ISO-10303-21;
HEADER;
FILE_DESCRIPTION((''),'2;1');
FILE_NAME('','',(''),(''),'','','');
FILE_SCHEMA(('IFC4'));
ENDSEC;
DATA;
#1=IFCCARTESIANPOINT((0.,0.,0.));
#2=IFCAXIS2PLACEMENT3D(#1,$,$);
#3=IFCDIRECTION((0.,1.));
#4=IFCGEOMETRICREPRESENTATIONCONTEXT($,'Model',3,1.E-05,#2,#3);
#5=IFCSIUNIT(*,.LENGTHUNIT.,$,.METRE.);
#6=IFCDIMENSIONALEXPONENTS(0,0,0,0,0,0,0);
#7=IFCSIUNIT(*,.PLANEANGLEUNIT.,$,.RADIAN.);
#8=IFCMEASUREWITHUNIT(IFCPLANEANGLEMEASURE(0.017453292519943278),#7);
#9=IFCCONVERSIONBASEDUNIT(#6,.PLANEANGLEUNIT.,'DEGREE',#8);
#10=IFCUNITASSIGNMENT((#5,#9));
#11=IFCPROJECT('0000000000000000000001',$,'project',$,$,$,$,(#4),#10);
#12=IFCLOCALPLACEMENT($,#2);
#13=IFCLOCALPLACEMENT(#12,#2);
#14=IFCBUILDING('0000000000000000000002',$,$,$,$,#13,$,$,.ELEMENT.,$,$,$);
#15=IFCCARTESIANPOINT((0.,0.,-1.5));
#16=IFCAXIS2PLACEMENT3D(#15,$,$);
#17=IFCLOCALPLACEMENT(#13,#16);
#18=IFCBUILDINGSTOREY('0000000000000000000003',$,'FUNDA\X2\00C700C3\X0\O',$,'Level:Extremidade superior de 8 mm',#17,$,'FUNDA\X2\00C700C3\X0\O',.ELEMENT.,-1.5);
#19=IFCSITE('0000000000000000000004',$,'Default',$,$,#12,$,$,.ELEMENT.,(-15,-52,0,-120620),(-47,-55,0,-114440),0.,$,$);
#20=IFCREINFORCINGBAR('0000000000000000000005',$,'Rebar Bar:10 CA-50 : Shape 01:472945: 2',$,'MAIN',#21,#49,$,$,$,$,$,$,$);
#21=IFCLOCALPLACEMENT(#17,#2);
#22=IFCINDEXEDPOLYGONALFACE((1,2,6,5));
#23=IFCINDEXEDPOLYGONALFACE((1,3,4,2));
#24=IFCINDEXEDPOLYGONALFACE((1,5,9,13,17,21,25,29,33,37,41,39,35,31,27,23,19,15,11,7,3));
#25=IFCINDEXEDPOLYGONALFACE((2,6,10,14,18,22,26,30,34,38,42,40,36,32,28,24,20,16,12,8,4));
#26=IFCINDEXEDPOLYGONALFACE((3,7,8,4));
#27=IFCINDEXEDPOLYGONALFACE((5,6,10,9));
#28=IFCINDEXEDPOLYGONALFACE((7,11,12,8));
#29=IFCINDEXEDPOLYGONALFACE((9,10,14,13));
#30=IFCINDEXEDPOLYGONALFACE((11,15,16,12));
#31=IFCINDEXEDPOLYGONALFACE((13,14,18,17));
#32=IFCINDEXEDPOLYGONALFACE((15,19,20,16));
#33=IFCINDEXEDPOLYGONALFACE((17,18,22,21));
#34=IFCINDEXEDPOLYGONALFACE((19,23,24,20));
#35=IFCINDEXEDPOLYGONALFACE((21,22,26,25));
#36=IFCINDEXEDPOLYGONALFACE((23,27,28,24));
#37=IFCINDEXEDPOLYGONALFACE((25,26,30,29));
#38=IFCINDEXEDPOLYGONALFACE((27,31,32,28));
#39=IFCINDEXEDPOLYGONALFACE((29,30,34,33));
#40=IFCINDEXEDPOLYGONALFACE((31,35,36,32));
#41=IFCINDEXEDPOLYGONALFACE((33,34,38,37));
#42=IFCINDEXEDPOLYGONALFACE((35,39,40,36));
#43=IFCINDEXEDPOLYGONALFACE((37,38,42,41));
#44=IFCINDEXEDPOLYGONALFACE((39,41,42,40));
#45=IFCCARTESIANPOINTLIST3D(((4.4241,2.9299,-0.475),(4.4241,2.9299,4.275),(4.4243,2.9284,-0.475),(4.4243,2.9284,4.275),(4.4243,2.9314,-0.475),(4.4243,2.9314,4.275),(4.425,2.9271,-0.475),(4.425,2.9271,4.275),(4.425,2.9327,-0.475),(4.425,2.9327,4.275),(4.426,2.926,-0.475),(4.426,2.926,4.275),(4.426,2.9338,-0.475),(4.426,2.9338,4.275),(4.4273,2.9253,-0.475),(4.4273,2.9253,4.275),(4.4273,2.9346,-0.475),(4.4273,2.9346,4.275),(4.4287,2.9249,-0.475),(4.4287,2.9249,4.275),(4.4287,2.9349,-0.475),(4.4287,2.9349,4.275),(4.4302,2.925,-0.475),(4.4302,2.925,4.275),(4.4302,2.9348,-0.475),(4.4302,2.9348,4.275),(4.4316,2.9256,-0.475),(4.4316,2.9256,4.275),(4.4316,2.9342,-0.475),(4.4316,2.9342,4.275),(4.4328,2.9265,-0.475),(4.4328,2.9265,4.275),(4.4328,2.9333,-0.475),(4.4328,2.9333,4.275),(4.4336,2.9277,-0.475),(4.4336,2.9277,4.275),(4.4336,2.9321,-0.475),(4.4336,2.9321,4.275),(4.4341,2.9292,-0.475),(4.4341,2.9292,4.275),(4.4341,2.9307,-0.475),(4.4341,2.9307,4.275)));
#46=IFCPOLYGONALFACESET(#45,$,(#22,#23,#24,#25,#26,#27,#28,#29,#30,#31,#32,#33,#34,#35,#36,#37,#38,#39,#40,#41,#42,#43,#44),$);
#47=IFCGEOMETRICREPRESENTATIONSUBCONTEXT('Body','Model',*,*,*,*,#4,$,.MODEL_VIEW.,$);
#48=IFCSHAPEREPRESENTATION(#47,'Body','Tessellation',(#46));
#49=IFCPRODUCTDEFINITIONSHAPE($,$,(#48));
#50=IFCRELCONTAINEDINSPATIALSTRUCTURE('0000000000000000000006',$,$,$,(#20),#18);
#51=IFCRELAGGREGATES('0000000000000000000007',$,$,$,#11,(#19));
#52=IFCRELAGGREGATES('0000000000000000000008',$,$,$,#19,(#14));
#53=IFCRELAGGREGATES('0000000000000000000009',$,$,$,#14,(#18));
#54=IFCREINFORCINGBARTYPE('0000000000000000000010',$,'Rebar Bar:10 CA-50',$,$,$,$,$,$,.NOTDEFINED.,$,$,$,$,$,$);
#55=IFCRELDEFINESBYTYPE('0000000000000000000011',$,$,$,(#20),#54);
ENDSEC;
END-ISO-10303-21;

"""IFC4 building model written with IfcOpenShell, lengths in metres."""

from ifc_helpers import new_model, entity, si_unit, converted_unit, direction, frame, origin, place, context, subcontext, project, spatial, type_object, element, save


model = new_model("IFC4")

# Units and contexts
model_context = context("Model", 3, precision=1e-05, world=origin(), true_north=direction((0.0, 1.0)))
body_context = subcontext(model_context, "Body", "Model", "MODEL_VIEW")
ifc_project = project(units=[si_unit("LENGTHUNIT", "METRE"), converted_unit("PLANEANGLEUNIT", "DEGREE", entity("IfcPlaneAngleMeasure", 0.017453292519943278), si_unit("PLANEANGLEUNIT", "RADIAN"), dimensions=[0, 0, 0, 0, 0, 0, 0])], contexts=[model_context])

# Site, building, storey
site_placement = place(None, origin())
site = spatial("IfcSite", under=ifc_project, at=site_placement, Name="Default", CompositionType="ELEMENT", RefLatitude=(-15, -52, 0, -120620), RefLongitude=(-47, -55, 0, -114440), RefElevation=0.0)
building_placement = place(site_placement, origin())
building = spatial("IfcBuilding", under=site, at=building_placement, CompositionType="ELEMENT")
storey_placement = place(building_placement, frame((0.0, 0.0, -1.5)))
storey = spatial("IfcBuildingStorey", under=building, at=storey_placement, Name="FUNDAÇÃO", ObjectType="Level:Extremidade superior de 8 mm", LongName="FUNDAÇÃO", CompositionType="ELEMENT", Elevation=-1.5)

# Reinforcing bar
reinforcing_bar_type_1 = type_object("IfcReinforcingBarType", Name="Rebar Bar:10 CA-50", PredefinedType="NOTDEFINED")
reinforcing_bar_1_placement = place(storey_placement, origin())
element("IfcReinforcingBar", 1, at=reinforcing_bar_1_placement, inside=storey, type_object=reinforcing_bar_type_1, Name="Rebar Bar:10 CA-50 : Shape 01:472945: 2", ObjectType="MAIN", context=body_context, shape_type="AdvancedSweptSolid", body=[
    entity("IfcSweptDiskSolid", entity("IfcIndexedPolyCurve", entity("IfcCartesianPointList3D", [[4.4291, 2.9299, 4.275], [4.4291, 2.9299, -0.475]]), None, False), 0.005, None, 0.0, 1.0),
])

save(model, "model.ifc")
